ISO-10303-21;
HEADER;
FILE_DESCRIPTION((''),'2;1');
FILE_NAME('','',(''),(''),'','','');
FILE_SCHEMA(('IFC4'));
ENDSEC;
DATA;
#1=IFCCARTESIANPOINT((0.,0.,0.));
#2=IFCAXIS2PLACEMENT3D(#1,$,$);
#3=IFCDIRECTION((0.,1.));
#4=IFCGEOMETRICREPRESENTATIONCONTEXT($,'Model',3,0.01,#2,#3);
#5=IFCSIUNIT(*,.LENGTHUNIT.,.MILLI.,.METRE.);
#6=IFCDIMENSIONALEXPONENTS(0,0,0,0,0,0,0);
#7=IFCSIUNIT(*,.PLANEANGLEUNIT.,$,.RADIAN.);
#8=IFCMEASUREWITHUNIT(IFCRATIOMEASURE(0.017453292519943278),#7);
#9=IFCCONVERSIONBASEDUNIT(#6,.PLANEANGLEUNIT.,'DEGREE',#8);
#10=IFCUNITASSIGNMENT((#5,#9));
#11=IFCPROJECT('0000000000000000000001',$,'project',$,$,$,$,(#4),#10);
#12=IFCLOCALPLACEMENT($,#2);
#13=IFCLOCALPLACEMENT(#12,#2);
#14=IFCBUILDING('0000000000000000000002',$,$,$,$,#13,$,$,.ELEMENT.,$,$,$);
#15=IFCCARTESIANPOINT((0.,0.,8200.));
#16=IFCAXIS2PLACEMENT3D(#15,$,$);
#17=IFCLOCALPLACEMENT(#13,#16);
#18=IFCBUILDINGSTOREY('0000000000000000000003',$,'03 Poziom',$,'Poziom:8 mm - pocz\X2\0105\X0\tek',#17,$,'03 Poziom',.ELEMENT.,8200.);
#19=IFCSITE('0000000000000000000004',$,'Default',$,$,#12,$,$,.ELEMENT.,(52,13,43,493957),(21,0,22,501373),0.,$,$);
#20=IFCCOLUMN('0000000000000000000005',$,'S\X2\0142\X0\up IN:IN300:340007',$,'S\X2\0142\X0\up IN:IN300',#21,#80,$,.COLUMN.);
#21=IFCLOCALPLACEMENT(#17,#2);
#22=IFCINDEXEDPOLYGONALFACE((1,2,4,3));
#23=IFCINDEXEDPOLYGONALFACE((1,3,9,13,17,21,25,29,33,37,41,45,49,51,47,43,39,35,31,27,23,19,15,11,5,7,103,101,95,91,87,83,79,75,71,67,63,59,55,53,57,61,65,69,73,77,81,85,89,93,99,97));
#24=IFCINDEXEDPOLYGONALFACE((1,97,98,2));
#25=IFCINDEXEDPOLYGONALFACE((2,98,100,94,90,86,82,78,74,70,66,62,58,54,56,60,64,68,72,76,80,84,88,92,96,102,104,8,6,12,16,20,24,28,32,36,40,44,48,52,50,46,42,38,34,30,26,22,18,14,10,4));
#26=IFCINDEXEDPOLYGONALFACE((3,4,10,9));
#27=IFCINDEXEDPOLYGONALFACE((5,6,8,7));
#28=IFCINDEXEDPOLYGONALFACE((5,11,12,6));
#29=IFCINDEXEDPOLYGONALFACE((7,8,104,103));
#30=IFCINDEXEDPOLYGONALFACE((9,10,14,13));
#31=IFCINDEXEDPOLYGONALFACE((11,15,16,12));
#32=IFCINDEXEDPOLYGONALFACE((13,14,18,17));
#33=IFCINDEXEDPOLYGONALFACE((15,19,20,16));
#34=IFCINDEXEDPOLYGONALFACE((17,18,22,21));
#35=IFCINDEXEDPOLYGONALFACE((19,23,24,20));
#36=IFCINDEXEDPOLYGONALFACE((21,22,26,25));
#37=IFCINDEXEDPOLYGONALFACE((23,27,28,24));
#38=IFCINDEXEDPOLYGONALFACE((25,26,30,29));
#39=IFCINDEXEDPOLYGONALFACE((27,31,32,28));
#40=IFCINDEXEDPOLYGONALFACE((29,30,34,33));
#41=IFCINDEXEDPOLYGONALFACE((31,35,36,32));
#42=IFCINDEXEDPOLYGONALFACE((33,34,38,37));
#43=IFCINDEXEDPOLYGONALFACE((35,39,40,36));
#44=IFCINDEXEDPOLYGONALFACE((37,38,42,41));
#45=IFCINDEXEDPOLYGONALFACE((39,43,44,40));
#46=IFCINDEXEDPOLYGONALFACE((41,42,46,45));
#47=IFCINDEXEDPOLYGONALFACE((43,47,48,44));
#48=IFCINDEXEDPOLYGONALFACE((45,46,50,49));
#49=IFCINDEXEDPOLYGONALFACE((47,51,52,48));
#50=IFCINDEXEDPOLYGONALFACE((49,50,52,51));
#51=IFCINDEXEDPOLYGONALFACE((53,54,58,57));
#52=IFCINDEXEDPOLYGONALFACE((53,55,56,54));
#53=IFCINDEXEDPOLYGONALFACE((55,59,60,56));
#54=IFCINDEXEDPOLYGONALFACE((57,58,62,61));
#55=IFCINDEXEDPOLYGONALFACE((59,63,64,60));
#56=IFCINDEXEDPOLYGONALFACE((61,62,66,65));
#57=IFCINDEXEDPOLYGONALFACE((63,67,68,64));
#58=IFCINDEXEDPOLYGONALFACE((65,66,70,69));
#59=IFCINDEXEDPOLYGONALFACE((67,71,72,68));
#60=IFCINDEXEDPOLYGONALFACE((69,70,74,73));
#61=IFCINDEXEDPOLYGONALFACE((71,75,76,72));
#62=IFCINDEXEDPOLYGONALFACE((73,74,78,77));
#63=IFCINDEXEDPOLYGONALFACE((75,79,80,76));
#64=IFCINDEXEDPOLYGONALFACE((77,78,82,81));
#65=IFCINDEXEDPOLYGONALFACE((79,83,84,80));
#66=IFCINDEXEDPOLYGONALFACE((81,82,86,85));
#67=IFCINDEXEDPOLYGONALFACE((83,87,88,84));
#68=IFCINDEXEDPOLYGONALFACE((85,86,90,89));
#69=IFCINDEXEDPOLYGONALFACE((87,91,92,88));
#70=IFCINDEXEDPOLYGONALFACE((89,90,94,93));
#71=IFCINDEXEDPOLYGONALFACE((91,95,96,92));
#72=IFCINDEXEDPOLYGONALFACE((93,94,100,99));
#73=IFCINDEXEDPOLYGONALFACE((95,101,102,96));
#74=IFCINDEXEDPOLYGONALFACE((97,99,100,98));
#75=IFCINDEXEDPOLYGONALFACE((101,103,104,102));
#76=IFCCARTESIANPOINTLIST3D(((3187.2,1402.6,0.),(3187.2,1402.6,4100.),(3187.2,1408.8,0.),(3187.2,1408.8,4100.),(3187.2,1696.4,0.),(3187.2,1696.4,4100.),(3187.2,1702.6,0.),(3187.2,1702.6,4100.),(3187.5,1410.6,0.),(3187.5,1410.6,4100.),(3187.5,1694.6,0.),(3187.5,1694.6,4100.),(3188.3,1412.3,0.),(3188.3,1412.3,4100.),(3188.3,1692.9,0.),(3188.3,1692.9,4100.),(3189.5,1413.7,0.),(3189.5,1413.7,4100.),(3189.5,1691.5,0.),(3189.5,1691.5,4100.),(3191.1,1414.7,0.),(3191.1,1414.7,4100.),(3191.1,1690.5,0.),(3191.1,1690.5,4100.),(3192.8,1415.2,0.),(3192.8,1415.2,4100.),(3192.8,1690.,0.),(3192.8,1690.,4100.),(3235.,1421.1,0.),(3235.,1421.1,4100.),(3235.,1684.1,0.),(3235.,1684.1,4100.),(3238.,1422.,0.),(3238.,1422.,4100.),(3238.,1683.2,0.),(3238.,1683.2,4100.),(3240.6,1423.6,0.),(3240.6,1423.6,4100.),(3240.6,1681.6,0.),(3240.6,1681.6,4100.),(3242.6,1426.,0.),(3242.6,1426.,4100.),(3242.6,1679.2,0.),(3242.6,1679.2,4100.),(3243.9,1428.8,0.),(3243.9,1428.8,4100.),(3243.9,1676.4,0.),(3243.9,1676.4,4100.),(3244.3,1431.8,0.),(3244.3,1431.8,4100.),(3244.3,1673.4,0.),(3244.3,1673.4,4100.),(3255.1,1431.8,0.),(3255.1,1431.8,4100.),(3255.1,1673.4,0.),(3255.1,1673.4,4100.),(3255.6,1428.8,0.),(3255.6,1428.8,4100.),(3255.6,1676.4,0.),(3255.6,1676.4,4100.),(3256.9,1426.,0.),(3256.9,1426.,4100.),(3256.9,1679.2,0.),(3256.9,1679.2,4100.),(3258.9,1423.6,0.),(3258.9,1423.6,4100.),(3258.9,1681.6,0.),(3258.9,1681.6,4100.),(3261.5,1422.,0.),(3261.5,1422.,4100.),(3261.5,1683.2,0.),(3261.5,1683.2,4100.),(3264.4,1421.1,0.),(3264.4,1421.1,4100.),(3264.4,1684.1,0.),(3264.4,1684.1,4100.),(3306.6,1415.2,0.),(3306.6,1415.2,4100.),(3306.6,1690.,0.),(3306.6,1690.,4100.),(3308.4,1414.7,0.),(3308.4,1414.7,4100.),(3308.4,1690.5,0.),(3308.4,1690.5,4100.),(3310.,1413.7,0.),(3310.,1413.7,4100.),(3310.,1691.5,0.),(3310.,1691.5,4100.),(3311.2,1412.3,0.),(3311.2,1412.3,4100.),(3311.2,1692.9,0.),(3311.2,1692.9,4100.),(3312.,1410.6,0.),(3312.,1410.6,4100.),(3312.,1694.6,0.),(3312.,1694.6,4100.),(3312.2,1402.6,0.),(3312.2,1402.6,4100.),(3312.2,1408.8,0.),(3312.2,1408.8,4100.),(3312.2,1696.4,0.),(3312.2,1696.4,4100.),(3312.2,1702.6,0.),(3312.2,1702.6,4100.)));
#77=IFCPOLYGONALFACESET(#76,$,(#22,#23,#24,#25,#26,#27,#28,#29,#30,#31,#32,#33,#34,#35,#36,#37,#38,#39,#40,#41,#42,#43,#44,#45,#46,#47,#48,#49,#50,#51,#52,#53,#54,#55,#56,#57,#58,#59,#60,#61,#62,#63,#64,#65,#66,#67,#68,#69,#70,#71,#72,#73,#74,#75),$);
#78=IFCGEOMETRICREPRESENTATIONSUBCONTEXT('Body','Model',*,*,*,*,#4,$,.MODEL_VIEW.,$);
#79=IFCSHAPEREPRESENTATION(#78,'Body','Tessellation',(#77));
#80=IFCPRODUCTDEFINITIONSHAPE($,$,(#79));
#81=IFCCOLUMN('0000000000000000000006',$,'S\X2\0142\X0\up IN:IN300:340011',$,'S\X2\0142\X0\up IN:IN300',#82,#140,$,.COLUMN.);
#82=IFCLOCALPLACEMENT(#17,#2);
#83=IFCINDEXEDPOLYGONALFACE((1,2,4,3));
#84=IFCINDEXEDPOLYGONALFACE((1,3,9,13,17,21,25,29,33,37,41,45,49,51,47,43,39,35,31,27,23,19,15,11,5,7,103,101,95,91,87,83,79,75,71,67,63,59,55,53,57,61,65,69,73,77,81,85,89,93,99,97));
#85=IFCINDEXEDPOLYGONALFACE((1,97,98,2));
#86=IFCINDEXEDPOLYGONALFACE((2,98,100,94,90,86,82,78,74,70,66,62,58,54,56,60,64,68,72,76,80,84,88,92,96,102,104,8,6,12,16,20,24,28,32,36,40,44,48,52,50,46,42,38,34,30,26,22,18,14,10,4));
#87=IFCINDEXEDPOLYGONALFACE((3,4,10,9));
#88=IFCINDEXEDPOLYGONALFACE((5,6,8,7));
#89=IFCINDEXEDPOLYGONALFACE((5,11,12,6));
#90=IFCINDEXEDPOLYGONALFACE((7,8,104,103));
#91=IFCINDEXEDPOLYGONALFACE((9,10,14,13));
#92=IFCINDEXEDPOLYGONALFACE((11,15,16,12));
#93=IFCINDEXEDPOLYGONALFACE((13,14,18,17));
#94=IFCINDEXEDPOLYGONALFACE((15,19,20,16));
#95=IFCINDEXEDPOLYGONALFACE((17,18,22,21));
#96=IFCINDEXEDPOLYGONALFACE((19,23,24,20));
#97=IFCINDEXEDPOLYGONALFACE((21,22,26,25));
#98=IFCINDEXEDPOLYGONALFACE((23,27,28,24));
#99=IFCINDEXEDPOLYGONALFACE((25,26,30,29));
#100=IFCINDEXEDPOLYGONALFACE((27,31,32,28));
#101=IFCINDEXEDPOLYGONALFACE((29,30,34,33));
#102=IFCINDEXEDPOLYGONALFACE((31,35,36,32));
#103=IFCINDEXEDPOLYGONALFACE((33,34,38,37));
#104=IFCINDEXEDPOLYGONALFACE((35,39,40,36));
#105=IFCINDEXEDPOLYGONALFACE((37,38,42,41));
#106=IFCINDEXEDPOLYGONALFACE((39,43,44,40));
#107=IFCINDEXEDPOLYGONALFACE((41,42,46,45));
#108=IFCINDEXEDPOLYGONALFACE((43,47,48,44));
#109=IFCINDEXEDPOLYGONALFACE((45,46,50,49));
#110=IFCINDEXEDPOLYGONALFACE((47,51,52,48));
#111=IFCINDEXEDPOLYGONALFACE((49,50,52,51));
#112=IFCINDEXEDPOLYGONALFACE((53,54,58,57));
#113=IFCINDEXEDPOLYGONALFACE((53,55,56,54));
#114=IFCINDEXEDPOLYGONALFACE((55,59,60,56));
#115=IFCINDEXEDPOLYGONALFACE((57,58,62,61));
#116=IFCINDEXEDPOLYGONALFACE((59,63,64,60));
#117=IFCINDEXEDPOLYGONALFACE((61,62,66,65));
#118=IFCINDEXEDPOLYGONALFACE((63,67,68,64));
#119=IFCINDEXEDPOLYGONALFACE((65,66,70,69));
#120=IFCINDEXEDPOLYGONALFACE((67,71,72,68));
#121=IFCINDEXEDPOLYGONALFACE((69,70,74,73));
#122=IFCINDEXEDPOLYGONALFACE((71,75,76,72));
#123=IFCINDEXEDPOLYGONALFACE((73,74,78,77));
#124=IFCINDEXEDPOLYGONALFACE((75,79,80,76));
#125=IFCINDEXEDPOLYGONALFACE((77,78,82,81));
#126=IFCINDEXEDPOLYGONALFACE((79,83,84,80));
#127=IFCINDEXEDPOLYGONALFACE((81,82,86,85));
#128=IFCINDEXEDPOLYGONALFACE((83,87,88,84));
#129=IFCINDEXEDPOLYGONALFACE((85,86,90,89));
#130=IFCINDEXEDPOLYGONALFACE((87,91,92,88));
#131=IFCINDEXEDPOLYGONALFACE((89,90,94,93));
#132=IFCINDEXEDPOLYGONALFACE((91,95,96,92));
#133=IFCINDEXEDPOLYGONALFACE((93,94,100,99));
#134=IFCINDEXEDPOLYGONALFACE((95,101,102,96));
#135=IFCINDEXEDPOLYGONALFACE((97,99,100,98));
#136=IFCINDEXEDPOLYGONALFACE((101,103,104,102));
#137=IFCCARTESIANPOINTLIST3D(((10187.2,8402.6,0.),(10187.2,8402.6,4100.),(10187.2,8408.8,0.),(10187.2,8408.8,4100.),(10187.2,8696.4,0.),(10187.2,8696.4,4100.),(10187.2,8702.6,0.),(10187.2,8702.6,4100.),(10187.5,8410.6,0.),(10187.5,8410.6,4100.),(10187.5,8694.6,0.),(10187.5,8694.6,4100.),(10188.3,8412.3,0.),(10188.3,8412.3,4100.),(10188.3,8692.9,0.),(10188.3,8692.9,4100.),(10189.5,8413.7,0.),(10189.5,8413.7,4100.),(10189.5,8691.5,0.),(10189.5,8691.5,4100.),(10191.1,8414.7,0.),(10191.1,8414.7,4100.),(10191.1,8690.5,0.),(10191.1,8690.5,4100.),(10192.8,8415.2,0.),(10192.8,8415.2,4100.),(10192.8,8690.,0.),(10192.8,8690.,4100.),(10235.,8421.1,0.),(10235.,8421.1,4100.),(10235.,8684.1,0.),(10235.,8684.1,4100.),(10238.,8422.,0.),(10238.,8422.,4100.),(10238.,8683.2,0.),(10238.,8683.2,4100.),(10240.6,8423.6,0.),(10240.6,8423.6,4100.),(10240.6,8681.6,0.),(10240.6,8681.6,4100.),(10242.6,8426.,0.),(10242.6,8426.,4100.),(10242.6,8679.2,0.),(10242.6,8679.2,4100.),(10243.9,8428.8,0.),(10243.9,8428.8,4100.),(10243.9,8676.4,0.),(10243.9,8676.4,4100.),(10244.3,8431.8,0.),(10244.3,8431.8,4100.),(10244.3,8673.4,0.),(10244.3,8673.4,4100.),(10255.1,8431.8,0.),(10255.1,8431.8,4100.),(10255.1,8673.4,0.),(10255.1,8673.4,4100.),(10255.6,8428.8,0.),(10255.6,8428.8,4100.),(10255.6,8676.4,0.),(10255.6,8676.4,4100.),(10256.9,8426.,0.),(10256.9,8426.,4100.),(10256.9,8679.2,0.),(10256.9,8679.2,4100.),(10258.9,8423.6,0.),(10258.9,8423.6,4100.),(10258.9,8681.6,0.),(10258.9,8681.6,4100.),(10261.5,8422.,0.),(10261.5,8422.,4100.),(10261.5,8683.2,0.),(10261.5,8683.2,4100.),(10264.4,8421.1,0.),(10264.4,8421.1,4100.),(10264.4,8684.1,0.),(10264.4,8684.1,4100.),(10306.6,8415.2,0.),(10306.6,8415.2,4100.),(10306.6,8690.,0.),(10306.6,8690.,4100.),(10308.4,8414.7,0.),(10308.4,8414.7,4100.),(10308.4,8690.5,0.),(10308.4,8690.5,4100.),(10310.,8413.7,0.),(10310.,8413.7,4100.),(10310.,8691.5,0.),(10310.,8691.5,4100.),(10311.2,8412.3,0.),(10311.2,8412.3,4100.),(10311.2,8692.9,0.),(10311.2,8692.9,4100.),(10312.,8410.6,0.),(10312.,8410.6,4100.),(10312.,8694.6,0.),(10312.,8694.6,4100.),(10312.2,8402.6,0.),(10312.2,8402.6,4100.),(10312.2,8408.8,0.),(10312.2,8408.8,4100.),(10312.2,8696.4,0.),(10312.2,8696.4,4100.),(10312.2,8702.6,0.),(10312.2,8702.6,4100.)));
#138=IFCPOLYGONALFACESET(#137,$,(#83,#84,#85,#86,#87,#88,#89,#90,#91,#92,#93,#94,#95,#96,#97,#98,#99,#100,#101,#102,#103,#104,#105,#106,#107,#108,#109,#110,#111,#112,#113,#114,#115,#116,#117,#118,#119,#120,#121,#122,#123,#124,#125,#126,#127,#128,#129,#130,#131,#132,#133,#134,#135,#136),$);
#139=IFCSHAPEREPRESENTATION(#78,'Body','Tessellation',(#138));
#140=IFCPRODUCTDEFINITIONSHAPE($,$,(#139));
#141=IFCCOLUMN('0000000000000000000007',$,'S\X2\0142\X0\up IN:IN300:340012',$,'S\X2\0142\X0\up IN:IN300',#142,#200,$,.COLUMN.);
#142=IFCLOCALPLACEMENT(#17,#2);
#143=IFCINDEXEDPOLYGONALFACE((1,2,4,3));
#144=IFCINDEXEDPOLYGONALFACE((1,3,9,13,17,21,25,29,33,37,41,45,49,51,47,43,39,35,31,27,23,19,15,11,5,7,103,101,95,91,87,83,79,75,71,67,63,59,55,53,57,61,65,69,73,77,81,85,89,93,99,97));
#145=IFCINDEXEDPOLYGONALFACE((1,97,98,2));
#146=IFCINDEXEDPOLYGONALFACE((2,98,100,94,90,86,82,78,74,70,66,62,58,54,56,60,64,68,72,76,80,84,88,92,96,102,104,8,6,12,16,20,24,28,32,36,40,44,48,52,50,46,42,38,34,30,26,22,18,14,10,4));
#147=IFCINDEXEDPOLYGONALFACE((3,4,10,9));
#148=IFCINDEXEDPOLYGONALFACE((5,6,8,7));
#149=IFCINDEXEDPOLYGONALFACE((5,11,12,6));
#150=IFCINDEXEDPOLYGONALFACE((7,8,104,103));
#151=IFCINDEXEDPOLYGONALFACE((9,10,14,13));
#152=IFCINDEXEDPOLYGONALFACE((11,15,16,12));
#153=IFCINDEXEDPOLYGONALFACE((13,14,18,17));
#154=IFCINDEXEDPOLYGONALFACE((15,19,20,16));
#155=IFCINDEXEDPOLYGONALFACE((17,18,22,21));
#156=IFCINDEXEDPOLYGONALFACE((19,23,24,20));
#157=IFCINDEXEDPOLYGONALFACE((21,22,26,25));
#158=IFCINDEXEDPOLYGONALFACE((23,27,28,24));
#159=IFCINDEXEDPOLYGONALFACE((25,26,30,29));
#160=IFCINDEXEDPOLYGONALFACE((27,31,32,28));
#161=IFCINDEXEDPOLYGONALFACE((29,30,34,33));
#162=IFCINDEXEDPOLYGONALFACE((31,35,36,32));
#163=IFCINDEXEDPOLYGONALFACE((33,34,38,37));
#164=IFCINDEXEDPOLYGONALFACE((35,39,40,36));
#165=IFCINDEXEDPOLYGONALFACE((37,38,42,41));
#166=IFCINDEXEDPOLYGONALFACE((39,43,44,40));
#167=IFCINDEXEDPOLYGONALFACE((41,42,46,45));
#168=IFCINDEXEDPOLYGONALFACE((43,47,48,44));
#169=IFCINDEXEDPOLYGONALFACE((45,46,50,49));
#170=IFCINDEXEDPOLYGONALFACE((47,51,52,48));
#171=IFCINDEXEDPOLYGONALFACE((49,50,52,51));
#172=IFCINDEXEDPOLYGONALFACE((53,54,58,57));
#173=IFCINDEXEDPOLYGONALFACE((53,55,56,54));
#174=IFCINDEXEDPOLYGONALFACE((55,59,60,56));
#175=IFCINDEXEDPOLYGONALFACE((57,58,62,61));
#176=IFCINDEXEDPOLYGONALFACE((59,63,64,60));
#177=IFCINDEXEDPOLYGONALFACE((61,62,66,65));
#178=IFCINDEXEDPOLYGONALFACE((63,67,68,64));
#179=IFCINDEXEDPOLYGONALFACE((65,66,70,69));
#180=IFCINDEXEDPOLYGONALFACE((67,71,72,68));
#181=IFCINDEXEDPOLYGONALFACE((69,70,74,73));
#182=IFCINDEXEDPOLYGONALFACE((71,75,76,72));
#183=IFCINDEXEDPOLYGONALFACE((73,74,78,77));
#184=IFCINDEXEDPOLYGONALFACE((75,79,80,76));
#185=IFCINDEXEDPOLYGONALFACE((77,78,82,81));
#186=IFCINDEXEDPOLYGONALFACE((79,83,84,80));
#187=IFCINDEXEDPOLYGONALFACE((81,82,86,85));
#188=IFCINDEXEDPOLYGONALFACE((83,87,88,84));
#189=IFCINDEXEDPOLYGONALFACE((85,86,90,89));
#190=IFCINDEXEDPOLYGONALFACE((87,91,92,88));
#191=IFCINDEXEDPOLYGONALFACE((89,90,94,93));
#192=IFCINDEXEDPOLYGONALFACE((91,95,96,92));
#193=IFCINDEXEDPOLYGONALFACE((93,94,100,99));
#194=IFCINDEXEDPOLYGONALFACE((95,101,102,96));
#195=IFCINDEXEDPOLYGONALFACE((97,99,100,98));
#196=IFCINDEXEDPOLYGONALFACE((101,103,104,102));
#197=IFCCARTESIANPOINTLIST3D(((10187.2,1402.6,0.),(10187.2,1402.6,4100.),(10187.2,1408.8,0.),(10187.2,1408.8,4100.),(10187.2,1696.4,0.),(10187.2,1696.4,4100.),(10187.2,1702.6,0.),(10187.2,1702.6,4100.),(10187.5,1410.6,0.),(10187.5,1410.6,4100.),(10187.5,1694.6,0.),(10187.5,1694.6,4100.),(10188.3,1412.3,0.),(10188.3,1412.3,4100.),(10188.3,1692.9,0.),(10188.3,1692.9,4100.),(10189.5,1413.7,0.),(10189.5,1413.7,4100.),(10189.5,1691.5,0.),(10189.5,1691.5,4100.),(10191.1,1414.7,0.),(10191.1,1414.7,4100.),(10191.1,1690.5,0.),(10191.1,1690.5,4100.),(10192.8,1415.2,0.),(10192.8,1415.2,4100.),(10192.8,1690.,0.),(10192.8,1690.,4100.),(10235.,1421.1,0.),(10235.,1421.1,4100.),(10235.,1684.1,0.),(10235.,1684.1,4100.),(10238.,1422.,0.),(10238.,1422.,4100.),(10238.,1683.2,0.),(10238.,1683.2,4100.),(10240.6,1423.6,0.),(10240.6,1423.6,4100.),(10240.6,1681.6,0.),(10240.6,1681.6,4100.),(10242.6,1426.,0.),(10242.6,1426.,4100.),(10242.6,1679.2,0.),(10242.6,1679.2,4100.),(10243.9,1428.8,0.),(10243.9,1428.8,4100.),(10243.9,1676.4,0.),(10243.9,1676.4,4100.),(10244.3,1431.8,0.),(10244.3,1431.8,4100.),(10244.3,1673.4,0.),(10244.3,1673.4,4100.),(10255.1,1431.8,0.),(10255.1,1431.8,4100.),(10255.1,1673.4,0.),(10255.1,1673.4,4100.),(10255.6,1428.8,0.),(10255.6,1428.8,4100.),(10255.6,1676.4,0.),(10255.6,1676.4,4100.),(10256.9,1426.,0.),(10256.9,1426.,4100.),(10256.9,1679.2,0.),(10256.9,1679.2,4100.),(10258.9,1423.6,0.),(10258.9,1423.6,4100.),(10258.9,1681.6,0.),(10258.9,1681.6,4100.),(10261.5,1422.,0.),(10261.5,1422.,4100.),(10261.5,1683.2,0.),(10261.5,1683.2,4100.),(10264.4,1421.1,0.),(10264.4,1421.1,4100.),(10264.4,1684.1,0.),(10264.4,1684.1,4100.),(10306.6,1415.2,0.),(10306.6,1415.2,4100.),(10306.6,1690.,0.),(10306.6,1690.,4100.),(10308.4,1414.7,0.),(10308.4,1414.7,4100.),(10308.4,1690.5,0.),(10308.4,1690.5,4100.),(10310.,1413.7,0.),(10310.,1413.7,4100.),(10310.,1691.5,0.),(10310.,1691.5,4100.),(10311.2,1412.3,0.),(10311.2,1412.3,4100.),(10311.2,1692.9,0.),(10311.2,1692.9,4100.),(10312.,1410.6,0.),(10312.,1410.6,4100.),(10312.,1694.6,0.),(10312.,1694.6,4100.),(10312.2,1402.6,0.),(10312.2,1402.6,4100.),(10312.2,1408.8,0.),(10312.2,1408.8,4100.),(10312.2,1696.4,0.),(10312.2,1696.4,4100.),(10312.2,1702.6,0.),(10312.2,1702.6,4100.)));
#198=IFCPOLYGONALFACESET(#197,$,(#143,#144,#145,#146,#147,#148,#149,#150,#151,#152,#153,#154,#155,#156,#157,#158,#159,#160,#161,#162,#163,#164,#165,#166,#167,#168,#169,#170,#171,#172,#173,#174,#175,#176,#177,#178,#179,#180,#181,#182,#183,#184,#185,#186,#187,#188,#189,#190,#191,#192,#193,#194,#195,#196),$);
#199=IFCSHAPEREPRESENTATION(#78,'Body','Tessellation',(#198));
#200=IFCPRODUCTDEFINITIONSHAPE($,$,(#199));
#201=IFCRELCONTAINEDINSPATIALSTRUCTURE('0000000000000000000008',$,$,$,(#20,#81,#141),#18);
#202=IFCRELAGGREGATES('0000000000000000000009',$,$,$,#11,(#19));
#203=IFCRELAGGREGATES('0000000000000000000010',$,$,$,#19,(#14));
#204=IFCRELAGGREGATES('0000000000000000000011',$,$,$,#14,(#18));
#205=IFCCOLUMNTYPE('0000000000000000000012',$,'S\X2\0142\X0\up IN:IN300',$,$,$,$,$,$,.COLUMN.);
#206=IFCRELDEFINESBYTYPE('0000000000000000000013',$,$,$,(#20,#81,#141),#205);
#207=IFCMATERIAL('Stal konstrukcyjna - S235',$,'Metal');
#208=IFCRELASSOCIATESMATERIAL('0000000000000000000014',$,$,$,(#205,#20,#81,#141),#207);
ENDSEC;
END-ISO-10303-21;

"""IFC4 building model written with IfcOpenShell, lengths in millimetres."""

from ifc_helpers import new_model, entity, si_unit, converted_unit, direction, frame, origin, place, context, subcontext, project, spatial, line, arc, indexed_curve, outline, extrude, source, transform, mapped, material, type_object, type_shapes, element, save


model = new_model("IFC4")

# Units and contexts
model_context = context("Model", 3, precision=0.01, world=origin(), true_north=direction((0.0, 1.0)))
body_context = subcontext(model_context, "Body", "Model", "MODEL_VIEW")
ifc_project = project(units=[si_unit("LENGTHUNIT", "METRE", prefix="MILLI"), converted_unit("PLANEANGLEUNIT", "DEGREE", entity("IfcRatioMeasure", 0.017453292519943278), si_unit("PLANEANGLEUNIT", "RADIAN"), dimensions=[0, 0, 0, 0, 0, 0, 0])], contexts=[model_context])

# Site, building, storey
site_placement = place(None, origin())
site = spatial("IfcSite", under=ifc_project, at=site_placement, Name="Default", CompositionType="ELEMENT", RefLatitude=(52, 13, 43, 493957), RefLongitude=(21, 0, 22, 501373), RefElevation=0.0)
building_placement = place(site_placement, origin())
building = spatial("IfcBuilding", under=site, at=building_placement, CompositionType="ELEMENT")
storey_placement = place(building_placement, frame((0.0, 0.0, 8200.0)))
storey = spatial("IfcBuildingStorey", under=building, at=storey_placement, Name="03 Poziom", ObjectType="Poziom:8 mm - początek", LongName="03 Poziom", CompositionType="ELEMENT", Elevation=8200.0)

# Columns
ifc_material_1 = material(Name="Stal konstrukcyjna - S235", Category="Metal")
column_type = type_object("IfcColumnType", Name="Słup IN:IN300", PredefinedType="COLUMN", material=ifc_material_1)
shared_shape_1 = source(origin(), body_context, "Body", "SweptSolid", [
    extrude(outline(indexed_curve([(143.8, -62.5), (150.0, -62.5), (150.0, 62.5), (143.8, 62.5), (139.6, 60.9), (137.4, 56.9), (131.5, 14.7), (127.9, 8.1), (120.8, 5.4), (-120.8, 5.4), (-127.9, 8.1), (-131.5, 14.7), (-137.4, 56.9), (-139.6, 60.9), (-143.8, 62.5), (-150.0, 62.5), (-150.0, -62.5), (-143.8, -62.5), (-139.6, -60.9), (-137.4, -56.9), (-131.5, -14.7), (-127.9, -8.1), (-120.8, -5.4), (120.8, -5.4), (127.9, -8.1), (131.5, -14.7), (137.4, -56.9), (139.6, -60.9)], segments=[line(1, 2, 3, 4), arc(4, 5, 6), line(6, 7), arc(7, 8, 9), line(9, 10), arc(10, 11, 12), line(12, 13), arc(13, 14, 15), line(15, 16, 17, 18), arc(18, 19, 20), line(20, 21), arc(21, 22, 23), line(23, 24), arc(24, 25, 26), line(26, 27), arc(27, 28, 1)], self_intersect=False)), frame((0.0, 0.0, 8200.0), z_axis=(0.0, 0.0, 1.0), x_axis=(0.0, -1.0, 0.0)), (0.0, 0.0, 1.0), 4100.0),
])
type_shapes(column_type, [shared_shape_1])
for number, where, name in (
    (1, (3249.7, 1552.6, -8200.0), "Słup IN:IN300:340007"),
    (2, (10249.7, 8552.6, -8200.0), "Słup IN:IN300:340011"),
    (3, (10249.7, 1552.6, -8200.0), "Słup IN:IN300:340012"),
):
    element("IfcColumn", number, at=place(storey_placement, frame(where)), inside=storey, type_object=column_type, material=ifc_material_1, Name=name, ObjectType="Słup IN:IN300", PredefinedType="COLUMN", context=body_context, shape_type="MappedRepresentation", body=[
        mapped(shared_shape_1, transform((0.0, 0.0, 0.0), scale=1.0)),
    ])

save(model, "model.ifc")
